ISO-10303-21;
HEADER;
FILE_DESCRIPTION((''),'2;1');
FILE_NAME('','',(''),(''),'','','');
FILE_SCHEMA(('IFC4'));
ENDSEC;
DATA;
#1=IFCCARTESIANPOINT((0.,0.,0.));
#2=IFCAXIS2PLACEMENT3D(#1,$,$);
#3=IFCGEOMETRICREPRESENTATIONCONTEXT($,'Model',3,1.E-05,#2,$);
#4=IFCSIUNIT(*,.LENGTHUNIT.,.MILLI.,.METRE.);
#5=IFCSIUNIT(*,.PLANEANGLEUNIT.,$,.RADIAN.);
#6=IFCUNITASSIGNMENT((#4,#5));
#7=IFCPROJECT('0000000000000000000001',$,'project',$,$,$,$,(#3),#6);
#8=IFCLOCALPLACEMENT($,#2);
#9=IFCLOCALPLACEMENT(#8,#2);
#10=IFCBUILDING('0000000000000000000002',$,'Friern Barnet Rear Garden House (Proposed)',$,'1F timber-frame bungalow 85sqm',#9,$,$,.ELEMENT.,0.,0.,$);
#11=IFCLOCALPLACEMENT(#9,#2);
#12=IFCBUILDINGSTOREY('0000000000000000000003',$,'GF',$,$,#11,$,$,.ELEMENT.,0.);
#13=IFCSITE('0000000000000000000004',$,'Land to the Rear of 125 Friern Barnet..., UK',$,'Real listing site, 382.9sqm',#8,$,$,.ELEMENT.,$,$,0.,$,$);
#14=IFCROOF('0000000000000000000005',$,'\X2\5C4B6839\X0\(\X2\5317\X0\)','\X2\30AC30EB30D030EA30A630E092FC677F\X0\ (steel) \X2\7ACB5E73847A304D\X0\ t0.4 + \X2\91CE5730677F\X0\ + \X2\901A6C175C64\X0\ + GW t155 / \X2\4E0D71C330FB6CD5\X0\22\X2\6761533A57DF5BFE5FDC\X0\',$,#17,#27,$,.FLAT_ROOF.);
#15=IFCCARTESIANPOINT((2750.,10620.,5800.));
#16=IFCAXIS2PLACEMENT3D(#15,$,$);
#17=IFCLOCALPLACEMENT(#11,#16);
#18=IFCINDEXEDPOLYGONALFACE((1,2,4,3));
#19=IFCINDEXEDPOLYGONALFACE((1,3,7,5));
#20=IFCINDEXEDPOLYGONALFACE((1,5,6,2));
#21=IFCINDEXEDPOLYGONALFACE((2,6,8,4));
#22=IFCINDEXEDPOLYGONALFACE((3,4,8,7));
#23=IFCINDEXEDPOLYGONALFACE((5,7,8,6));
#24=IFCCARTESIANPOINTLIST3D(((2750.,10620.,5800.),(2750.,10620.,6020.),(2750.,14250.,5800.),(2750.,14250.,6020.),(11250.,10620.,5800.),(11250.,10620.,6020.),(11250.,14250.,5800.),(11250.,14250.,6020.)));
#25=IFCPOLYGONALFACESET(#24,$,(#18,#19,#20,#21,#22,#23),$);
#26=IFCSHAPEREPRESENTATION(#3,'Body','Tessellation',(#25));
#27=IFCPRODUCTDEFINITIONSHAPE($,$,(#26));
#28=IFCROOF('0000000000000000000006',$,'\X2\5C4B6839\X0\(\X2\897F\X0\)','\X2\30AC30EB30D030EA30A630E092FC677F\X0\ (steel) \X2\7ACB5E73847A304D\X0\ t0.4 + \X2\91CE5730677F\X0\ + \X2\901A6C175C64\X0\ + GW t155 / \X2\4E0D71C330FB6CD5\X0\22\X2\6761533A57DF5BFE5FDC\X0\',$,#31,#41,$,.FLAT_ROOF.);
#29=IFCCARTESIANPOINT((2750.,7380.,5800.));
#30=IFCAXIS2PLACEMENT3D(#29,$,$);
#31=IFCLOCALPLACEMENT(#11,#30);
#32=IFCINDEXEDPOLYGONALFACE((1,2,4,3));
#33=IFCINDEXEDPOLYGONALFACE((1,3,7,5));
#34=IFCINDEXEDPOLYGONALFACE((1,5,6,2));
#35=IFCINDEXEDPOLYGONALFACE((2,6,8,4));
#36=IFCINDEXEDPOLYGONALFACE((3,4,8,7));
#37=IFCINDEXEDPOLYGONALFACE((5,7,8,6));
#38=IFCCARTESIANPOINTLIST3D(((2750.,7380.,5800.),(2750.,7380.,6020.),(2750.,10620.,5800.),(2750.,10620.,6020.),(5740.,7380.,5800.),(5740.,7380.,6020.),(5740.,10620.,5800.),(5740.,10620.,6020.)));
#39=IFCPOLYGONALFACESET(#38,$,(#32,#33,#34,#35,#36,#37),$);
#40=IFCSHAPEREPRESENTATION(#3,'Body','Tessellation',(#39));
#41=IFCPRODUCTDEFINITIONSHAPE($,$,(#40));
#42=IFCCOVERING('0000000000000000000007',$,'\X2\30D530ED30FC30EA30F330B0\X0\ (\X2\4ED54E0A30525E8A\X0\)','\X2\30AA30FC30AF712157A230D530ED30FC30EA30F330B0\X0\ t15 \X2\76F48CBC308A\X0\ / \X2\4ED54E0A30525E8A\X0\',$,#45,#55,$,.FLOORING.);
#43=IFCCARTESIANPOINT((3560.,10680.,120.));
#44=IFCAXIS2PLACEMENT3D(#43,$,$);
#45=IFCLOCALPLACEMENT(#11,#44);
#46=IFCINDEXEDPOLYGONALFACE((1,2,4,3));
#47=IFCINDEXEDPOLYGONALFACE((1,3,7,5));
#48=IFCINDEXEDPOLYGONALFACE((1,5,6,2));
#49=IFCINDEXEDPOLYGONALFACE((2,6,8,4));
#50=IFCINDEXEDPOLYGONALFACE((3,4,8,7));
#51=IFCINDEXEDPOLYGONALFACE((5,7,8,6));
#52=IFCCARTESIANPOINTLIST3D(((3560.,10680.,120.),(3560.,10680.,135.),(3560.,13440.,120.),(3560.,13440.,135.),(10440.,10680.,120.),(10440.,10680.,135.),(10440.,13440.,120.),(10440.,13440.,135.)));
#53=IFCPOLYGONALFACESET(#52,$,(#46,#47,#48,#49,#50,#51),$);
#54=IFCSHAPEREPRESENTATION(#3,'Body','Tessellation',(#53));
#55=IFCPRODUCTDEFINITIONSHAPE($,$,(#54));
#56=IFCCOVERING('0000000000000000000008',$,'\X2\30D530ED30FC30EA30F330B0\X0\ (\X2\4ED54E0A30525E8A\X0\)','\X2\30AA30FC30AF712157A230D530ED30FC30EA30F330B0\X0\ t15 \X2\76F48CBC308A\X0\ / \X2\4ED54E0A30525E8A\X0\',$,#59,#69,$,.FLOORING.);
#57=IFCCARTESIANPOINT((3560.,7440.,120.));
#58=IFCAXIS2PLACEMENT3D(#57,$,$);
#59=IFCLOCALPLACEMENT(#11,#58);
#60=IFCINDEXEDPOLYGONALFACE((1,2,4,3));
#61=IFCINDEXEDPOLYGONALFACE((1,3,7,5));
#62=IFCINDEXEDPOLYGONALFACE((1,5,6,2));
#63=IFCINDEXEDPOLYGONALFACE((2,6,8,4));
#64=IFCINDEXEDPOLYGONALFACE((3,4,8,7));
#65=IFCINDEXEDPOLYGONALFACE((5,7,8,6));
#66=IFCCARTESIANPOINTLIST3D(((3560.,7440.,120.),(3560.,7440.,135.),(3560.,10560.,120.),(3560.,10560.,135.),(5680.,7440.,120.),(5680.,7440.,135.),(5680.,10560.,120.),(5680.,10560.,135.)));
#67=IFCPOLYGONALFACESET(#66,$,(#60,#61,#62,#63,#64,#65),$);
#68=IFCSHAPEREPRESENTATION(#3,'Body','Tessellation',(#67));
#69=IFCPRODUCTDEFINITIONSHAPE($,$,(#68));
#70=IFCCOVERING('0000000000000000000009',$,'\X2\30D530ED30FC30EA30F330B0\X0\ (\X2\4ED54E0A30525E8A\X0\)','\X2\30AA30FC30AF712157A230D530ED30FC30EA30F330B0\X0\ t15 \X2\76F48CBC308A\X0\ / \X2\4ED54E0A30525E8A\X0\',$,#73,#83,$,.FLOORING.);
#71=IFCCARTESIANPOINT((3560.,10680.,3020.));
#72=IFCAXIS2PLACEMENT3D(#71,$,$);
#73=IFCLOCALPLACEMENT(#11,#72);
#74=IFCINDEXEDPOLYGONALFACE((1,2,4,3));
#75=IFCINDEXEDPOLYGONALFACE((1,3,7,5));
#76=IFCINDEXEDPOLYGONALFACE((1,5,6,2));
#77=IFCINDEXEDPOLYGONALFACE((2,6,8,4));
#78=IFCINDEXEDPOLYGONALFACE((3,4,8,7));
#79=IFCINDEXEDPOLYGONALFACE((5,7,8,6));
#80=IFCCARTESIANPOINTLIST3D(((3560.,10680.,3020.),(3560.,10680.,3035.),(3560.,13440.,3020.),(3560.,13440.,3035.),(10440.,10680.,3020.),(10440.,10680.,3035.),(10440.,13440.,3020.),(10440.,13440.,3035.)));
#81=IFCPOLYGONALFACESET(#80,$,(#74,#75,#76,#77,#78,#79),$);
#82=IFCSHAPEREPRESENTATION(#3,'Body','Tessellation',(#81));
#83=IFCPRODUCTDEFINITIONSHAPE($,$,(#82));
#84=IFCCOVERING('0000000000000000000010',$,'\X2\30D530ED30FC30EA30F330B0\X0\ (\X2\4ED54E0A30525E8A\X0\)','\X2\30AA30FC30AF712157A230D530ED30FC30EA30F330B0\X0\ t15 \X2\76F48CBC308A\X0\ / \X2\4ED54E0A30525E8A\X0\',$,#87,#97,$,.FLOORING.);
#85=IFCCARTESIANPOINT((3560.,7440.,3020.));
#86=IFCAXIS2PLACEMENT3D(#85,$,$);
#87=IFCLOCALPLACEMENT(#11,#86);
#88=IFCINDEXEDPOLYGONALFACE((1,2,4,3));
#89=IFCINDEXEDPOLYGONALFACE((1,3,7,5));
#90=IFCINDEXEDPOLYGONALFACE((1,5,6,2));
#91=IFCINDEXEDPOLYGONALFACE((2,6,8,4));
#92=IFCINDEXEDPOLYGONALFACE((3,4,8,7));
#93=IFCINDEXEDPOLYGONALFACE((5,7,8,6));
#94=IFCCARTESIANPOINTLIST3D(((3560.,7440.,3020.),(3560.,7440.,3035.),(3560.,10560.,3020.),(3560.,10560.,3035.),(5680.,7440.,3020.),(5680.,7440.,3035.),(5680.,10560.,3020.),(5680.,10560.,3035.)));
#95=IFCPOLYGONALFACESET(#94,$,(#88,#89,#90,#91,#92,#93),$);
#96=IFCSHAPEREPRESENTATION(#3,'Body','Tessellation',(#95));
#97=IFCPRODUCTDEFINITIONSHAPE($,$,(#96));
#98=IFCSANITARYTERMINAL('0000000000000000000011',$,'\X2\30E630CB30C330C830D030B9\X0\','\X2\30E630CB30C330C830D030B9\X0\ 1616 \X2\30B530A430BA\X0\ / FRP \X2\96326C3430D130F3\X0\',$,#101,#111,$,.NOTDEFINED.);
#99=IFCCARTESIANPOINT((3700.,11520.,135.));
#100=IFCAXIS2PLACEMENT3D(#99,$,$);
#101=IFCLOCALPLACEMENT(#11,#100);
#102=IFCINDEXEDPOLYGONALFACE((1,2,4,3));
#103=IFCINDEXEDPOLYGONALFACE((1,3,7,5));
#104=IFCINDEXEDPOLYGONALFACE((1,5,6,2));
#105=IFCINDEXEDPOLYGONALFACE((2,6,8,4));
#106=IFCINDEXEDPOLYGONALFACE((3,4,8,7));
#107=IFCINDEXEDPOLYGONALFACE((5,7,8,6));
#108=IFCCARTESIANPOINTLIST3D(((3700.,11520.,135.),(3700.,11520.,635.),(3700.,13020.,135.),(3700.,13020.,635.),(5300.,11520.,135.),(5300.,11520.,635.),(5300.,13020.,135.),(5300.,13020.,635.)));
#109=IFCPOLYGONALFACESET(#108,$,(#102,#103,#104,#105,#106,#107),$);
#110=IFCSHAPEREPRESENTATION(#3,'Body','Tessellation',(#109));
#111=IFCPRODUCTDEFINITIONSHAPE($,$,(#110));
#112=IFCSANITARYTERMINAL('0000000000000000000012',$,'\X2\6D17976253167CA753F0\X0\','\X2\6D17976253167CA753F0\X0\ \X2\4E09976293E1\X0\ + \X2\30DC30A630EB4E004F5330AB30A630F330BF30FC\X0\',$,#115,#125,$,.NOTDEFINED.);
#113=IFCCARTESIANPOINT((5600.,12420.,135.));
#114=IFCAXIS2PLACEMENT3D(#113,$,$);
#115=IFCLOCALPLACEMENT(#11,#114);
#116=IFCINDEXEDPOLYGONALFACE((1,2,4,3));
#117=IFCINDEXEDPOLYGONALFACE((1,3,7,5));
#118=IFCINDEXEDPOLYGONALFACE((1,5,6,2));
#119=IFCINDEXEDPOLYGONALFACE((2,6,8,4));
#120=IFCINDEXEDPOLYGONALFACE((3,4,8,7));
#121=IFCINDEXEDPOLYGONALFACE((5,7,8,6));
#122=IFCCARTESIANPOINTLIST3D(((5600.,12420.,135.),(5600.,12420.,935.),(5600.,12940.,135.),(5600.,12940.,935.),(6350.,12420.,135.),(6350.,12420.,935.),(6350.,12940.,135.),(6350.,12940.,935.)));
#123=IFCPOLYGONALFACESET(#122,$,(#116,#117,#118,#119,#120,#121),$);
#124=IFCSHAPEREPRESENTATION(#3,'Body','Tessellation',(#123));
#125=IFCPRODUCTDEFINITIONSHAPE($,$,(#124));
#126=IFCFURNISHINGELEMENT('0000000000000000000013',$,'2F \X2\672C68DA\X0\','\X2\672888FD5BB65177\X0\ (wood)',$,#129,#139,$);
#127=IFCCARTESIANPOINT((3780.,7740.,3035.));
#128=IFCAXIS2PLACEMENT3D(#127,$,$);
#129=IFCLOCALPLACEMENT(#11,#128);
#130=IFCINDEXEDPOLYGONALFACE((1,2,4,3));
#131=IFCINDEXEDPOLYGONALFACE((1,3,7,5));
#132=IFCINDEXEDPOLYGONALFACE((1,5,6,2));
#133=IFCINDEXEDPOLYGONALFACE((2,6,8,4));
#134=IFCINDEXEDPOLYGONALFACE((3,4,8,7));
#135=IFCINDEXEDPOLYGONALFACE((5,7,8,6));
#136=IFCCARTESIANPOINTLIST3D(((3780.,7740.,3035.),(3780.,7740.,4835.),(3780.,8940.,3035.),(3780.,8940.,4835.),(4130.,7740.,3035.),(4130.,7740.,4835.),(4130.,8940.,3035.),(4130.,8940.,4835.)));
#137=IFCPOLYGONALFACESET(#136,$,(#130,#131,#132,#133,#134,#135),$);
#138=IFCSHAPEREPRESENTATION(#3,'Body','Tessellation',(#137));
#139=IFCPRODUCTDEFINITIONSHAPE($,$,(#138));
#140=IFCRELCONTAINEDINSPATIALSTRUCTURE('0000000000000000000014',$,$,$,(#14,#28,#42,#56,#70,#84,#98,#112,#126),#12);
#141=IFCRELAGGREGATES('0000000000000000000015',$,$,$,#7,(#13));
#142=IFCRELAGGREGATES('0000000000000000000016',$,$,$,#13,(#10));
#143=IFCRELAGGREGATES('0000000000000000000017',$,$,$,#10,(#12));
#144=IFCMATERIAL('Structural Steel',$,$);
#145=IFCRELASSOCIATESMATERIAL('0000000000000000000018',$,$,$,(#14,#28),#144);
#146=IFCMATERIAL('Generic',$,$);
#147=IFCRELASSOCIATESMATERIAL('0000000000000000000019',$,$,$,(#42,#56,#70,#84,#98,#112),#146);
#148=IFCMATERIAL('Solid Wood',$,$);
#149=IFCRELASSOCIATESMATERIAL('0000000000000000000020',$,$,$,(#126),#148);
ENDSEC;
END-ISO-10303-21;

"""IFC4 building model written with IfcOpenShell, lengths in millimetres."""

from ifc_helpers import new_model, si_unit, frame, frame_2d, origin, place, context, project, spatial, rectangle, extrude, material, element, save


model = new_model("IFC4")

# Units and contexts
model_context = context("Model", 3, precision=1e-05, world=origin())
ifc_project = project(units=[si_unit("LENGTHUNIT", "METRE", prefix="MILLI"), si_unit("PLANEANGLEUNIT", "RADIAN")], contexts=[model_context])

# Site, building, storey
site_placement = place(None, origin())
site = spatial("IfcSite", under=ifc_project, at=site_placement, Name="Land to the Rear of 125 Friern Barnet..., UK", ObjectType="Real listing site, 382.9sqm", CompositionType="ELEMENT", RefElevation=0.0)
building_placement = place(site_placement, origin())
building = spatial("IfcBuilding", under=site, at=building_placement, Name="Friern Barnet Rear Garden House (Proposed)", ObjectType="1F timber-frame bungalow 85sqm", CompositionType="ELEMENT", ElevationOfRefHeight=0.0, ElevationOfTerrain=0.0)
storey_placement = place(building_placement, origin())
storey = spatial("IfcBuildingStorey", under=building, at=storey_placement, Name="GF", CompositionType="ELEMENT", Elevation=0.0)

# Shared definitions
ifc_material_1 = material(Name="Solid Wood")

# Roofs
ifc_material_2 = material(Name="Structural Steel")
for number, where, name in (
    (1, (2750.0, 10620.0, 5800.0), "屋根(北)"),
):
    element("IfcRoof", number, at=place(storey_placement, frame(where)), inside=storey, material=ifc_material_2, Name=name, Description="ガルバリウム鋼板 (steel) 立平葺き t0.4 + 野地板 + 通気層 + GW t155 / 不燃・法22条区域対応", PredefinedType="FLAT_ROOF", context=model_context, shape_type="SweptSolid", body=[
        extrude(rectangle(XDim=8500.0, YDim=3630.0, at=frame_2d((4250.0, 1815.0))), frame((2750.0, 10620.0, 5800.0)), (0.0, 0.0, 1.0), 220.0),
    ])
roof_placement = place(storey_placement, frame((2750.0, 7380.0, 5800.0)))
element("IfcRoof", 2, at=roof_placement, inside=storey, material=ifc_material_2, Name="屋根(西)", Description="ガルバリウム鋼板 (steel) 立平葺き t0.4 + 野地板 + 通気層 + GW t155 / 不燃・法22条区域対応", PredefinedType="FLAT_ROOF", context=model_context, shape_type="SweptSolid", body=[
    extrude(rectangle(XDim=2990.0, YDim=3240.0, at=frame_2d((1495.0, 1620.0))), frame((2750.0, 7380.0, 5800.0)), (0.0, 0.0, 1.0), 220.0),
])

# Coverings
ifc_material_3 = material(Name="Generic")
covering_1_placement = place(storey_placement, frame((3560.0, 10680.0, 120.0)))
element("IfcCovering", 3, at=covering_1_placement, inside=storey, material=ifc_material_3, Name="フローリング (仕上げ床)", Description="オーク無垢フローリング t15 直貼り / 仕上げ床", PredefinedType="FLOORING", context=model_context, shape_type="SweptSolid", body=[
    extrude(rectangle(XDim=6880.0, YDim=2760.0, at=frame_2d((3440.0, 1380.0))), frame((3560.0, 10680.0, 120.0)), (0.0, 0.0, 1.0), 15.0),
])
covering_2_placement = place(storey_placement, frame((3560.0, 7440.0, 120.0)))
element("IfcCovering", 4, at=covering_2_placement, inside=storey, material=ifc_material_3, Name="フローリング (仕上げ床)", Description="オーク無垢フローリング t15 直貼り / 仕上げ床", PredefinedType="FLOORING", context=model_context, shape_type="SweptSolid", body=[
    extrude(rectangle(XDim=2120.0, YDim=3120.0, at=frame_2d((1060.0, 1560.0))), frame((3560.0, 7440.0, 120.0)), (0.0, 0.0, 1.0), 15.0),
])
covering_3_placement = place(storey_placement, frame((3560.0, 10680.0, 3020.0)))
element("IfcCovering", 5, at=covering_3_placement, inside=storey, material=ifc_material_3, Name="フローリング (仕上げ床)", Description="オーク無垢フローリング t15 直貼り / 仕上げ床", PredefinedType="FLOORING", context=model_context, shape_type="SweptSolid", body=[
    extrude(rectangle(XDim=6880.0, YDim=2760.0, at=frame_2d((3440.0, 1380.0))), frame((3560.0, 10680.0, 3020.0)), (0.0, 0.0, 1.0), 15.0),
])
covering_4_placement = place(storey_placement, frame((3560.0, 7440.0, 3020.0)))
element("IfcCovering", 6, at=covering_4_placement, inside=storey, material=ifc_material_3, Name="フローリング (仕上げ床)", Description="オーク無垢フローリング t15 直貼り / 仕上げ床", PredefinedType="FLOORING", context=model_context, shape_type="SweptSolid", body=[
    extrude(rectangle(XDim=2120.0, YDim=3120.0, at=frame_2d((1060.0, 1560.0))), frame((3560.0, 7440.0, 3020.0)), (0.0, 0.0, 1.0), 15.0),
])

# Sanitary terminals
sanitary_terminal_1_placement = place(storey_placement, frame((3700.0, 11520.0, 135.0)))
element("IfcSanitaryTerminal", 7, at=sanitary_terminal_1_placement, inside=storey, material=ifc_material_3, Name="ユニットバス", Description="ユニットバス 1616 サイズ / FRP 防水パン", PredefinedType="NOTDEFINED", context=model_context, shape_type="SweptSolid", body=[
    extrude(rectangle(XDim=1600.0, YDim=1500.0, at=frame_2d((800.0, 750.0))), frame((3700.0, 11520.0, 135.0)), (0.0, 0.0, 1.0), 500.0),
])
sanitary_terminal_2_placement = place(storey_placement, frame((5600.0, 12420.0, 135.0)))
element("IfcSanitaryTerminal", 8, at=sanitary_terminal_2_placement, inside=storey, material=ifc_material_3, Name="洗面化粧台", Description="洗面化粧台 三面鏡 + ボウル一体カウンター", PredefinedType="NOTDEFINED", context=model_context, shape_type="SweptSolid", body=[
    extrude(rectangle(XDim=750.0, YDim=520.0, at=frame_2d((375.0, 260.0))), frame((5600.0, 12420.0, 135.0)), (0.0, 0.0, 1.0), 800.0),
])

# Furnishing element
furnishing_placement = place(storey_placement, frame((3780.0, 7740.0, 3035.0)))
element("IfcFurnishingElement", 9, at=furnishing_placement, inside=storey, material=ifc_material_1, Name="2F 本棚", Description="木製家具 (wood)", context=model_context, shape_type="SweptSolid", body=[
    extrude(rectangle(XDim=350.0, YDim=1200.0, at=frame_2d((175.0, 600.0))), frame((3780.0, 7740.0, 3035.0)), (0.0, 0.0, 1.0), 1800.0),
])

save(model, "model.ifc")
